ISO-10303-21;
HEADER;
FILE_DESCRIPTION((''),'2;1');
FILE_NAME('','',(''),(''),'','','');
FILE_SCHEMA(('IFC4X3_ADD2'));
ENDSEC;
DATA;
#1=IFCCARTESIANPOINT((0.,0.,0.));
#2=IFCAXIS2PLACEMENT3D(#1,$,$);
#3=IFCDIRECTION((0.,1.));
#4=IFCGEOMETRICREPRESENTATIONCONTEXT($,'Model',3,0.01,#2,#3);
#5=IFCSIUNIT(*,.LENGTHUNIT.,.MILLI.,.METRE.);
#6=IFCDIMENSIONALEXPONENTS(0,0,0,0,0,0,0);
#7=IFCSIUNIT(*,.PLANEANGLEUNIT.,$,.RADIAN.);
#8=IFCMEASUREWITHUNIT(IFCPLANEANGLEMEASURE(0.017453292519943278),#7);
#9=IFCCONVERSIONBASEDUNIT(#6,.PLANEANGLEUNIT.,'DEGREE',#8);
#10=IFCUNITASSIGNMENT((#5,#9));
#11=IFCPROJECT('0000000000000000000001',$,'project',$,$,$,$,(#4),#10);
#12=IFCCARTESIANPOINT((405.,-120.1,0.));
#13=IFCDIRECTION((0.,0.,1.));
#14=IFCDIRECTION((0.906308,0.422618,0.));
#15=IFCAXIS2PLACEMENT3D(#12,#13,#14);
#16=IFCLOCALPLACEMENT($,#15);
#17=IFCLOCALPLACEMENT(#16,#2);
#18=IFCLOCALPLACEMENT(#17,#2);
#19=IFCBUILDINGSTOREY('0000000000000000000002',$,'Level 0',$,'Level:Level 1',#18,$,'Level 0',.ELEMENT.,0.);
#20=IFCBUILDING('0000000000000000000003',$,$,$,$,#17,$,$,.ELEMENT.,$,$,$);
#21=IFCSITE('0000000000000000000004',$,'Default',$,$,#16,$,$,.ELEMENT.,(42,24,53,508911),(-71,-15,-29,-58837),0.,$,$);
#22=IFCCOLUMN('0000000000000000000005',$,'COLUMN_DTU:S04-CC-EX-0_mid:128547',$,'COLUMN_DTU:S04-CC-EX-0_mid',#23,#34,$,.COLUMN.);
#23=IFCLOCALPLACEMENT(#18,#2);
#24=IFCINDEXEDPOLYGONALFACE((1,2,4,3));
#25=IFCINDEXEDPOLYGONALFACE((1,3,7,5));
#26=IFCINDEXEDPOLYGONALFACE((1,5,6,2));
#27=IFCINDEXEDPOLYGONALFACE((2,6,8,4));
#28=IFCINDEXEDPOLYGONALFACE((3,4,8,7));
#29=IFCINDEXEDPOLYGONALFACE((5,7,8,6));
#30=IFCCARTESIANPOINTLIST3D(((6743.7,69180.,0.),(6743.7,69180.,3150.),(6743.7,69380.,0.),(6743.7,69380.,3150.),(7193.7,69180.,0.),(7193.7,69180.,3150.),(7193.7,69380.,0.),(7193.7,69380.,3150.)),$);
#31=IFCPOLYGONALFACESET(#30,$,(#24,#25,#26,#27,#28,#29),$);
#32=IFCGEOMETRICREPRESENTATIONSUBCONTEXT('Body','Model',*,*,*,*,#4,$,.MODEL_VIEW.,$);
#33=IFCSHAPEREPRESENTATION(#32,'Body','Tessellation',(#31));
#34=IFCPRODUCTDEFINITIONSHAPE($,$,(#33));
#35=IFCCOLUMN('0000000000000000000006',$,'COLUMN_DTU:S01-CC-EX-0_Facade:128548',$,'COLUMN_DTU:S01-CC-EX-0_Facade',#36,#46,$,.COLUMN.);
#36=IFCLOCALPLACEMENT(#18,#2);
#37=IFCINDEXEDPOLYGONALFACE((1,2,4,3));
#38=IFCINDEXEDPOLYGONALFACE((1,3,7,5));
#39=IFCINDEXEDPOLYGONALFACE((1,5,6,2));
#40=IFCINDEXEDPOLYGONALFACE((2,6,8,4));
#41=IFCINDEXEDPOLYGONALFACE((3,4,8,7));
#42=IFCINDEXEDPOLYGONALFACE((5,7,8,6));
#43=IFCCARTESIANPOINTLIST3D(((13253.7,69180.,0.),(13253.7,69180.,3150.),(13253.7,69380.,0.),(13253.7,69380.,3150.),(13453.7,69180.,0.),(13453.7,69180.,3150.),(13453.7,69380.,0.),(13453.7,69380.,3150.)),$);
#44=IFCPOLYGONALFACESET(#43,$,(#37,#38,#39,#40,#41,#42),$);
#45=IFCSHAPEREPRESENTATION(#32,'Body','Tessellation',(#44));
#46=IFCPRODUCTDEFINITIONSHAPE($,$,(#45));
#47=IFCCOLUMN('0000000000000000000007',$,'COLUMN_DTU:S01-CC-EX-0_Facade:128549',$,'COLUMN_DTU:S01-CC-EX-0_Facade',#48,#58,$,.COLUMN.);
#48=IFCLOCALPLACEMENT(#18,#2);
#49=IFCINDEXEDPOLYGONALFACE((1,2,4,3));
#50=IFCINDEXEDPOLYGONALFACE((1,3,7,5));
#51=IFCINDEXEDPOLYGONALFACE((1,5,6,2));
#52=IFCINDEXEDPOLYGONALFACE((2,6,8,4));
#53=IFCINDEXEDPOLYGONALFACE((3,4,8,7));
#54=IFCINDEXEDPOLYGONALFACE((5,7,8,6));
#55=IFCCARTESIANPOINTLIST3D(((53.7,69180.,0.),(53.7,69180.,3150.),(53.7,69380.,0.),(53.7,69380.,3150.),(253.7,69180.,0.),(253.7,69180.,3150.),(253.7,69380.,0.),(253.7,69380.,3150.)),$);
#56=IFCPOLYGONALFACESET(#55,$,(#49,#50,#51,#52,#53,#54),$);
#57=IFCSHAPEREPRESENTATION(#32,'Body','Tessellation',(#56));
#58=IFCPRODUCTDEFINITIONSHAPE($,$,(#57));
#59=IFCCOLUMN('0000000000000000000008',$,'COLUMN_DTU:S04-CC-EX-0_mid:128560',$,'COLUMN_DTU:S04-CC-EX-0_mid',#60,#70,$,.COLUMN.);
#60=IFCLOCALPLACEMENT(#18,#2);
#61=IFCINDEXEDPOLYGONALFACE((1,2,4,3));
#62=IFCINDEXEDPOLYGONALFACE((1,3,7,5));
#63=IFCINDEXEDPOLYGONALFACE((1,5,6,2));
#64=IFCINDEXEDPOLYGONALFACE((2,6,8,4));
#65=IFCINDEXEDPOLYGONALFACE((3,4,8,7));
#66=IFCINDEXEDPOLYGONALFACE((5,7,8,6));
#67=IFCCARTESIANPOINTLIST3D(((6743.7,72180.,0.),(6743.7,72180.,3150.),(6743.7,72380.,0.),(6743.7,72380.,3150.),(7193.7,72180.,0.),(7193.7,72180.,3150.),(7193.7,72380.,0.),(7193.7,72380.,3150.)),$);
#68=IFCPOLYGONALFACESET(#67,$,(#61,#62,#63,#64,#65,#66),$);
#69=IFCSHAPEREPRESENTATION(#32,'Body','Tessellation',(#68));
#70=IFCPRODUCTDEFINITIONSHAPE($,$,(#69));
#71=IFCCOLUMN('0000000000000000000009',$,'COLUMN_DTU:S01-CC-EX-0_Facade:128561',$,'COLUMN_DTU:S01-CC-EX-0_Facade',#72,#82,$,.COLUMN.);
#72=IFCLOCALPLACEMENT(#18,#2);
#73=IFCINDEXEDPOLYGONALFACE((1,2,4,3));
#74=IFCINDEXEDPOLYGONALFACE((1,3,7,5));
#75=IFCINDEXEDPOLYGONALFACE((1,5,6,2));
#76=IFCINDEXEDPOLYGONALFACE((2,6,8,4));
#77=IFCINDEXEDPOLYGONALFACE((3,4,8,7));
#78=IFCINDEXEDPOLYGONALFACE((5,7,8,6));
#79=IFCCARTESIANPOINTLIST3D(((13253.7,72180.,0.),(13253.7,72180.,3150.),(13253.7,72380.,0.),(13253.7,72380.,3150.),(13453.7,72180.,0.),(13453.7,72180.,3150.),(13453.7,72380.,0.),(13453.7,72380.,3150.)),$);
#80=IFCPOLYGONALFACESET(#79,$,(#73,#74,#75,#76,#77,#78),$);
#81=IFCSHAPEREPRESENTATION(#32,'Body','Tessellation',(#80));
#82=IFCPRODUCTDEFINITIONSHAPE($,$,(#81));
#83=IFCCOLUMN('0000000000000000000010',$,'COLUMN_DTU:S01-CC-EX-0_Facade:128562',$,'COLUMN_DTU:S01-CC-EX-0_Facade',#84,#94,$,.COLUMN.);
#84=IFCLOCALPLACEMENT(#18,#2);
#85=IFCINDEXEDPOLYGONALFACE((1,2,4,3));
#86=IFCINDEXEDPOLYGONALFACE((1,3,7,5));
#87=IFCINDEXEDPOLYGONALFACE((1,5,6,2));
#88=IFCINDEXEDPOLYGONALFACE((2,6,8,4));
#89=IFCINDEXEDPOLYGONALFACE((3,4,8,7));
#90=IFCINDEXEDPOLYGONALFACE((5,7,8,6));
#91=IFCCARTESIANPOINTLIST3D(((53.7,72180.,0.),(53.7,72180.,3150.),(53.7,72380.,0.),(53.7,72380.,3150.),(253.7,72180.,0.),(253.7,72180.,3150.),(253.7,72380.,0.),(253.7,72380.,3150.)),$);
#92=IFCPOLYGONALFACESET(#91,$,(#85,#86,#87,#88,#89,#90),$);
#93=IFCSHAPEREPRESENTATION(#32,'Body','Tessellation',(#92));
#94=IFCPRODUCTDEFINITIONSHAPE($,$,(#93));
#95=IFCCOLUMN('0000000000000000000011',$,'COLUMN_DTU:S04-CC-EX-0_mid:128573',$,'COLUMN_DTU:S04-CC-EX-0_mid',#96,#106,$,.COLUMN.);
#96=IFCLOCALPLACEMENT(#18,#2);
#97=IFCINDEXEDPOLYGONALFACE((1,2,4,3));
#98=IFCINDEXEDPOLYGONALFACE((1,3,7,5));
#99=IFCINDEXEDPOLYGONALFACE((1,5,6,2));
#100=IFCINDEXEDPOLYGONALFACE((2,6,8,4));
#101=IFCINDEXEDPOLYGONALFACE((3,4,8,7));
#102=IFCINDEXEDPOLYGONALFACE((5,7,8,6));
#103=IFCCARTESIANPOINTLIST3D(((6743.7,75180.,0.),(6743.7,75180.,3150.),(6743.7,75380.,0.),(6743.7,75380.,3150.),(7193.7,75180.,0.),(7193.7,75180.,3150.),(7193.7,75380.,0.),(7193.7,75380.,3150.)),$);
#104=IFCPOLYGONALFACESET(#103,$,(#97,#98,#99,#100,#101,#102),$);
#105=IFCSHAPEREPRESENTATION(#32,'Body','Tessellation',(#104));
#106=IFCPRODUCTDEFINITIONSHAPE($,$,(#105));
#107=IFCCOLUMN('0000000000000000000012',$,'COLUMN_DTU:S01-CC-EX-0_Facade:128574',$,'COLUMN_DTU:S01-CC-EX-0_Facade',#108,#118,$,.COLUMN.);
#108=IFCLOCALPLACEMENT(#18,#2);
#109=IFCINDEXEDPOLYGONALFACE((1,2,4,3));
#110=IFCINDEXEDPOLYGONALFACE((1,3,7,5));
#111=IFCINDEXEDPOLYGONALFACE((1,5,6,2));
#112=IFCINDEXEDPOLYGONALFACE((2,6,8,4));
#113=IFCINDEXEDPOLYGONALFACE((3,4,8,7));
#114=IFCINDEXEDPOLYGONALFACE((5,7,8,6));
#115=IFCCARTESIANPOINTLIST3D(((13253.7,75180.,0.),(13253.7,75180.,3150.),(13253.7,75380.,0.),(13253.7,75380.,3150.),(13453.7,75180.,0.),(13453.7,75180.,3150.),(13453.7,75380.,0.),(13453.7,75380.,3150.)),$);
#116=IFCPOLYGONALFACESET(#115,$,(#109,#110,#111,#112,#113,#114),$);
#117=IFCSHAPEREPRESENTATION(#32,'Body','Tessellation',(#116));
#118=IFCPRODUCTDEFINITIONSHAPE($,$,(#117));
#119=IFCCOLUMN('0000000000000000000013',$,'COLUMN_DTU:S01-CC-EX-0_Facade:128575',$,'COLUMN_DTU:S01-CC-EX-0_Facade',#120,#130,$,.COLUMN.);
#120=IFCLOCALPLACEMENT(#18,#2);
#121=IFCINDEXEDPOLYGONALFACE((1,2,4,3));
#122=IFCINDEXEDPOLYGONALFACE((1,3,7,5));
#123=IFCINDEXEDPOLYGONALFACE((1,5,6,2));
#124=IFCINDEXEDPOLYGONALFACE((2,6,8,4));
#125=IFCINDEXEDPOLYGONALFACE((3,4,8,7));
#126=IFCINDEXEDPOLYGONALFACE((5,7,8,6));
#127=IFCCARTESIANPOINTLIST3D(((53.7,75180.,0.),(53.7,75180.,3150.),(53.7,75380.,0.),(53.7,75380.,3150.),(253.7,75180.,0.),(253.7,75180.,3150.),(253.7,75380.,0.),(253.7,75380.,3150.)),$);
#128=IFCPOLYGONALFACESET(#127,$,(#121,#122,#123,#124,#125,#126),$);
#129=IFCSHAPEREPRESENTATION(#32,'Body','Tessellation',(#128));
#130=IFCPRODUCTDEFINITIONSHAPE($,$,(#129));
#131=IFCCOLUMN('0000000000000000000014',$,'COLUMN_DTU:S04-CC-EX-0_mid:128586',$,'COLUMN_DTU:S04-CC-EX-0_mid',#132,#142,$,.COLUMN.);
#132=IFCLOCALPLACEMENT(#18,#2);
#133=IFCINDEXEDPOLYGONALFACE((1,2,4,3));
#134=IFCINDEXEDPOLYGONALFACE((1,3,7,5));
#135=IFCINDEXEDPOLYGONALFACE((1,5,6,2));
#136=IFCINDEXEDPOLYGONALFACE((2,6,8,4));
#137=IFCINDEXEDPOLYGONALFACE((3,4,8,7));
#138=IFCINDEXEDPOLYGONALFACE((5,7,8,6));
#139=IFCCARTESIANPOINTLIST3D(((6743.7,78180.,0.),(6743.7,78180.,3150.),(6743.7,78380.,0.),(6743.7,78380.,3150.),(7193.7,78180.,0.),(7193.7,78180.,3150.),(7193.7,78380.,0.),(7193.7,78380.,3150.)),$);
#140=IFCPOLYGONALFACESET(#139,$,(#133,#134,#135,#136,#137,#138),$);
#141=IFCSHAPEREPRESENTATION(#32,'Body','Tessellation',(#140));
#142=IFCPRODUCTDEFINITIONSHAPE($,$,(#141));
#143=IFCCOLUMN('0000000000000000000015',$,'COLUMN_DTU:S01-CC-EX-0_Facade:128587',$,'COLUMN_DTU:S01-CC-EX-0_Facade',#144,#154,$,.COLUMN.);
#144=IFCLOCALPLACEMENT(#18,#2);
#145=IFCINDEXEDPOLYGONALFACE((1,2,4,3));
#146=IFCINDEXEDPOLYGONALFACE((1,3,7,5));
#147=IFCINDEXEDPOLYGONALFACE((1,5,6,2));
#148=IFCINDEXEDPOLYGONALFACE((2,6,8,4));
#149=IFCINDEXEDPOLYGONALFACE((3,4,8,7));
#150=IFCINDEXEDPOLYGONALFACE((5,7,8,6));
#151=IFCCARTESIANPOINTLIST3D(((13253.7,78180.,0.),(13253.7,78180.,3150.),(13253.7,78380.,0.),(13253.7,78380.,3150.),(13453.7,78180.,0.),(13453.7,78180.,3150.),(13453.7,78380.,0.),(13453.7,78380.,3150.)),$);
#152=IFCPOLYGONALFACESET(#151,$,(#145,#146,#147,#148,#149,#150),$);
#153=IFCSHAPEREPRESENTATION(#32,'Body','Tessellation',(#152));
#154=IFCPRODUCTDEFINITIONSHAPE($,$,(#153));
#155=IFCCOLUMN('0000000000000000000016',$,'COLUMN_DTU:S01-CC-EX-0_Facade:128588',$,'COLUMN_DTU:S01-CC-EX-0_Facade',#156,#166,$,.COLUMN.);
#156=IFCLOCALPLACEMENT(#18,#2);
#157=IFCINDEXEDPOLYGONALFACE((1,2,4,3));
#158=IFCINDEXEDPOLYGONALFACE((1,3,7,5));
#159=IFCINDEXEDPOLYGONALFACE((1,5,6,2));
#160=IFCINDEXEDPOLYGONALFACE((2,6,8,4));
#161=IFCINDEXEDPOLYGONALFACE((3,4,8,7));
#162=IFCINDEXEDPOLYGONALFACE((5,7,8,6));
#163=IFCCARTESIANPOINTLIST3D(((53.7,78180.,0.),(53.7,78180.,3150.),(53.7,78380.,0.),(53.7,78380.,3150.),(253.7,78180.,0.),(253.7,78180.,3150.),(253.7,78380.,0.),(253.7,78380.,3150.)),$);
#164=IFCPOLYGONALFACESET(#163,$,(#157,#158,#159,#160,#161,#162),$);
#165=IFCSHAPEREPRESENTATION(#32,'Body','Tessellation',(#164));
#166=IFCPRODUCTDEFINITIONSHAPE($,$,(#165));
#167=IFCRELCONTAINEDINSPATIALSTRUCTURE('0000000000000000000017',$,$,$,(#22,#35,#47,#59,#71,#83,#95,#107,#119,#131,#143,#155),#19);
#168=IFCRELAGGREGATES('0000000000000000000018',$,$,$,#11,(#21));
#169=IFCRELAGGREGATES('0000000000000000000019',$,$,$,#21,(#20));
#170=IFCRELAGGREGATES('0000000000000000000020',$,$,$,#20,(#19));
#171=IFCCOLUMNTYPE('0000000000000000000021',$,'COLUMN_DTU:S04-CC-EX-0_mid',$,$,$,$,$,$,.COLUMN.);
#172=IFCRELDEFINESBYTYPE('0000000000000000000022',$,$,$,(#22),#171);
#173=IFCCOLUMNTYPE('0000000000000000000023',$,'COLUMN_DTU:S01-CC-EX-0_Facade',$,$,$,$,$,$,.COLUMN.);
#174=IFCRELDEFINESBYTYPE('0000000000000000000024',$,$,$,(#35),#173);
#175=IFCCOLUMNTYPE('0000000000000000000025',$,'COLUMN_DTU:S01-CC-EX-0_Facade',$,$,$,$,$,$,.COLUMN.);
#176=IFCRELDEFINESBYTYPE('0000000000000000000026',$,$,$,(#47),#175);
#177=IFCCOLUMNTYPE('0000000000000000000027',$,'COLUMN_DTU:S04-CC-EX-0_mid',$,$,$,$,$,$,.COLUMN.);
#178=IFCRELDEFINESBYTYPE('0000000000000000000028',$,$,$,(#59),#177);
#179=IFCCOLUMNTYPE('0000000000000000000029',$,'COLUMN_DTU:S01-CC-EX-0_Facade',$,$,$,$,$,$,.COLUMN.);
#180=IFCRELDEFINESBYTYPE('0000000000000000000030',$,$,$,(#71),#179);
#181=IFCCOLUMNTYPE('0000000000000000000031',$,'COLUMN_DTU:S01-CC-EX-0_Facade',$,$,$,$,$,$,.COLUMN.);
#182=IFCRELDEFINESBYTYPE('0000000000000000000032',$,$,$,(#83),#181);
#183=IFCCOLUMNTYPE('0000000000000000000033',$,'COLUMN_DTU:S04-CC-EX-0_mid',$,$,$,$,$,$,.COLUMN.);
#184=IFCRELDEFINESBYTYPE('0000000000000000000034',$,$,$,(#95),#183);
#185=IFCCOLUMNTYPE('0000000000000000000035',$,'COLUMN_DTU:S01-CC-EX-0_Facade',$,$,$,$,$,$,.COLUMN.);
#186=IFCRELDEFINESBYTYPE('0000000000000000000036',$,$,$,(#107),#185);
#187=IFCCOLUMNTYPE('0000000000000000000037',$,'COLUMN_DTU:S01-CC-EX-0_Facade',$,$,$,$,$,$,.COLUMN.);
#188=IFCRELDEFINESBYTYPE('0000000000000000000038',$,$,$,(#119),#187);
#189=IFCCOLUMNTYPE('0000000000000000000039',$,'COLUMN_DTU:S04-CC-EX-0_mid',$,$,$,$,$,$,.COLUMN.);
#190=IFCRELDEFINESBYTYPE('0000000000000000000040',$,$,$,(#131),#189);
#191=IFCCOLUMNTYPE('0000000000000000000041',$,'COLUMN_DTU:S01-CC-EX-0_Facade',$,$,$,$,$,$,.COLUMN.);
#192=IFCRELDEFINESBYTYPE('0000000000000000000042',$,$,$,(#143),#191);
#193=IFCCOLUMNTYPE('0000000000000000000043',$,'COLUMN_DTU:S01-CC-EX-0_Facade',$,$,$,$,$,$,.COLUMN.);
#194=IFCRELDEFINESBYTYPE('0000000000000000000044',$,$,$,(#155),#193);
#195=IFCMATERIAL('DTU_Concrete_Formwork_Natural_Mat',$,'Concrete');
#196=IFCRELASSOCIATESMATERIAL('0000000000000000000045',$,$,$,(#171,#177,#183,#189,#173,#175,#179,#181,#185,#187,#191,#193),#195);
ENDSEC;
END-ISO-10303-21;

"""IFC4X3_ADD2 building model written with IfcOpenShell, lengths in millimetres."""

from ifc_helpers import new_model, entity, si_unit, converted_unit, direction, frame, frame_2d, origin, place, context, subcontext, project, spatial, rectangle, extrude, source, transform, mapped, material, material_profile, profile_set, type_object, type_shapes, element, save


model = new_model("IFC4X3_ADD2")

# Units and contexts
model_context = context("Model", 3, precision=0.01, world=origin(), true_north=direction((0.0, 1.0)))
body_context = subcontext(model_context, "Body", "Model", "MODEL_VIEW")
ifc_project = project(units=[si_unit("LENGTHUNIT", "METRE", prefix="MILLI"), converted_unit("PLANEANGLEUNIT", "DEGREE", entity("IfcPlaneAngleMeasure", 0.017453292519943278), si_unit("PLANEANGLEUNIT", "RADIAN"), dimensions=[0, 0, 0, 0, 0, 0, 0])], contexts=[model_context])

# Site, building, storey
site_placement = place(None, frame((405.0, -120.1, 0.0), z_axis=(0.0, 0.0, 1.0), x_axis=(0.906308, 0.422618, 0.0)))
site = spatial("IfcSite", under=ifc_project, at=site_placement, Name="Default", CompositionType="ELEMENT", RefLatitude=(42, 24, 53, 508911), RefLongitude=(-71, -15, -29, -58837), RefElevation=0.0)
building_placement = place(site_placement, origin())
building = spatial("IfcBuilding", under=site, at=building_placement, CompositionType="ELEMENT")
storey_placement = place(building_placement, origin())
storey = spatial("IfcBuildingStorey", under=building, at=storey_placement, Name="Level 0", ObjectType="Level:Level 1", LongName="Level 0", CompositionType="ELEMENT", Elevation=0.0)

# Columns
ifc_material = material(Name="DTU_Concrete_Formwork_Natural_Mat", Category="Concrete")
ifc_material_profile_1 = material_profile(ifc_material, rectangle(XDim=200.0, YDim=200.0, at=frame_2d((0.0, 0.0), x_axis=(1.0, 0.0))), Name="S01-CC-EX-0_Facade")
ifc_profile_set_1 = profile_set([ifc_material_profile_1], Name="S01-CC-EX-0_Facade")
ifc_material_profile_2 = material_profile(ifc_material, rectangle(XDim=200.0, YDim=450.0, at=frame_2d((0.0, 0.0), x_axis=(1.0, 0.0))), Name="S04-CC-EX-0_mid")
ifc_profile_set_2 = profile_set([ifc_material_profile_2], Name="S04-CC-EX-0_mid")
column_type_1 = type_object("IfcColumnType", Name="COLUMN_DTU:S04-CC-EX-0_mid", PredefinedType="COLUMN", material=ifc_profile_set_2)
shared_shape_1 = source(origin(), body_context, "Body", "SweptSolid", [
    extrude(rectangle(XDim=200.0, YDim=450.0, at=frame_2d((0.0, 0.0), x_axis=(1.0, 0.0))), frame((6968.7, 69280.0, 0.0), z_axis=(0.0, 0.0, 1.0), x_axis=(0.0, 1.0, 0.0)), (0.0, 0.0, 1.0), 3150.0),
])
type_shapes(column_type_1, [shared_shape_1])
column_1_placement = place(storey_placement, origin())
element("IfcColumn", 1, at=column_1_placement, inside=storey, type_object=column_type_1, Name="COLUMN_DTU:S04-CC-EX-0_mid:128547", ObjectType="COLUMN_DTU:S04-CC-EX-0_mid", PredefinedType="COLUMN", context=body_context, shape_type="MappedRepresentation", body=[
    mapped(shared_shape_1, transform((0.0, 0.0, 0.0), scale=1.0)),
])
column_type_2 = type_object("IfcColumnType", Name="COLUMN_DTU:S01-CC-EX-0_Facade", PredefinedType="COLUMN", material=ifc_profile_set_1)
shared_shape_2 = source(origin(), body_context, "Body", "SweptSolid", [
    extrude(rectangle(XDim=200.0, YDim=200.0, at=frame_2d((0.0, 0.0), x_axis=(1.0, 0.0))), frame((13353.7, 69280.0, 0.0), z_axis=(0.0, 0.0, 1.0), x_axis=(0.0, 1.0, 0.0)), (0.0, 0.0, 1.0), 3150.0),
])
type_shapes(column_type_2, [shared_shape_2])
column_2_placement = place(storey_placement, origin())
element("IfcColumn", 2, at=column_2_placement, inside=storey, type_object=column_type_2, Name="COLUMN_DTU:S01-CC-EX-0_Facade:128548", ObjectType="COLUMN_DTU:S01-CC-EX-0_Facade", PredefinedType="COLUMN", context=body_context, shape_type="MappedRepresentation", body=[
    mapped(shared_shape_2, transform((0.0, 0.0, 0.0), scale=1.0)),
])
column_type_3 = type_object("IfcColumnType", Name="COLUMN_DTU:S01-CC-EX-0_Facade", PredefinedType="COLUMN", material=ifc_profile_set_1)
shared_shape_3 = source(origin(), body_context, "Body", "SweptSolid", [
    extrude(rectangle(XDim=200.0, YDim=200.0, at=frame_2d((0.0, 0.0), x_axis=(1.0, 0.0))), frame((153.7, 69280.0, 0.0), z_axis=(0.0, 0.0, 1.0), x_axis=(0.0, 1.0, 0.0)), (0.0, 0.0, 1.0), 3150.0),
])
type_shapes(column_type_3, [shared_shape_3])
column_3_placement = place(storey_placement, origin())
element("IfcColumn", 3, at=column_3_placement, inside=storey, type_object=column_type_3, Name="COLUMN_DTU:S01-CC-EX-0_Facade:128549", ObjectType="COLUMN_DTU:S01-CC-EX-0_Facade", PredefinedType="COLUMN", context=body_context, shape_type="MappedRepresentation", body=[
    mapped(shared_shape_3, transform((0.0, 0.0, 0.0), scale=1.0)),
])
column_type_4 = type_object("IfcColumnType", Name="COLUMN_DTU:S04-CC-EX-0_mid", PredefinedType="COLUMN", material=ifc_profile_set_2)
shared_shape_4 = source(origin(), body_context, "Body", "SweptSolid", [
    extrude(rectangle(XDim=200.0, YDim=450.0, at=frame_2d((0.0, 0.0), x_axis=(1.0, 0.0))), frame((6968.7, 72280.0, 0.0), z_axis=(0.0, 0.0, 1.0), x_axis=(0.0, 1.0, 0.0)), (0.0, 0.0, 1.0), 3150.0),
])
type_shapes(column_type_4, [shared_shape_4])
column_4_placement = place(storey_placement, origin())
element("IfcColumn", 4, at=column_4_placement, inside=storey, type_object=column_type_4, Name="COLUMN_DTU:S04-CC-EX-0_mid:128560", ObjectType="COLUMN_DTU:S04-CC-EX-0_mid", PredefinedType="COLUMN", context=body_context, shape_type="MappedRepresentation", body=[
    mapped(shared_shape_4, transform((0.0, 0.0, 0.0), scale=1.0)),
])
column_type_5 = type_object("IfcColumnType", Name="COLUMN_DTU:S01-CC-EX-0_Facade", PredefinedType="COLUMN", material=ifc_profile_set_1)
shared_shape_5 = source(origin(), body_context, "Body", "SweptSolid", [
    extrude(rectangle(XDim=200.0, YDim=200.0, at=frame_2d((0.0, 0.0), x_axis=(1.0, 0.0))), frame((13353.7, 72280.0, 0.0), z_axis=(0.0, 0.0, 1.0), x_axis=(0.0, 1.0, 0.0)), (0.0, 0.0, 1.0), 3150.0),
])
type_shapes(column_type_5, [shared_shape_5])
column_5_placement = place(storey_placement, origin())
element("IfcColumn", 5, at=column_5_placement, inside=storey, type_object=column_type_5, Name="COLUMN_DTU:S01-CC-EX-0_Facade:128561", ObjectType="COLUMN_DTU:S01-CC-EX-0_Facade", PredefinedType="COLUMN", context=body_context, shape_type="MappedRepresentation", body=[
    mapped(shared_shape_5, transform((0.0, 0.0, 0.0), scale=1.0)),
])
column_type_6 = type_object("IfcColumnType", Name="COLUMN_DTU:S01-CC-EX-0_Facade", PredefinedType="COLUMN", material=ifc_profile_set_1)
shared_shape_6 = source(origin(), body_context, "Body", "SweptSolid", [
    extrude(rectangle(XDim=200.0, YDim=200.0, at=frame_2d((0.0, 0.0), x_axis=(1.0, 0.0))), frame((153.7, 72280.0, 0.0), z_axis=(0.0, 0.0, 1.0), x_axis=(0.0, 1.0, 0.0)), (0.0, 0.0, 1.0), 3150.0),
])
type_shapes(column_type_6, [shared_shape_6])
column_6_placement = place(storey_placement, origin())
element("IfcColumn", 6, at=column_6_placement, inside=storey, type_object=column_type_6, Name="COLUMN_DTU:S01-CC-EX-0_Facade:128562", ObjectType="COLUMN_DTU:S01-CC-EX-0_Facade", PredefinedType="COLUMN", context=body_context, shape_type="MappedRepresentation", body=[
    mapped(shared_shape_6, transform((0.0, 0.0, 0.0), scale=1.0)),
])
column_type_7 = type_object("IfcColumnType", Name="COLUMN_DTU:S04-CC-EX-0_mid", PredefinedType="COLUMN", material=ifc_profile_set_2)
shared_shape_7 = source(origin(), body_context, "Body", "SweptSolid", [
    extrude(rectangle(XDim=200.0, YDim=450.0, at=frame_2d((0.0, 0.0), x_axis=(1.0, 0.0))), frame((6968.7, 75280.0, 0.0), z_axis=(0.0, 0.0, 1.0), x_axis=(0.0, 1.0, 0.0)), (0.0, 0.0, 1.0), 3150.0),
])
type_shapes(column_type_7, [shared_shape_7])
column_7_placement = place(storey_placement, origin())
element("IfcColumn", 7, at=column_7_placement, inside=storey, type_object=column_type_7, Name="COLUMN_DTU:S04-CC-EX-0_mid:128573", ObjectType="COLUMN_DTU:S04-CC-EX-0_mid", PredefinedType="COLUMN", context=body_context, shape_type="MappedRepresentation", body=[
    mapped(shared_shape_7, transform((0.0, 0.0, 0.0), scale=1.0)),
])
column_type_8 = type_object("IfcColumnType", Name="COLUMN_DTU:S01-CC-EX-0_Facade", PredefinedType="COLUMN", material=ifc_profile_set_1)
shared_shape_8 = source(origin(), body_context, "Body", "SweptSolid", [
    extrude(rectangle(XDim=200.0, YDim=200.0, at=frame_2d((0.0, 0.0), x_axis=(1.0, 0.0))), frame((13353.7, 75280.0, 0.0), z_axis=(0.0, 0.0, 1.0), x_axis=(0.0, 1.0, 0.0)), (0.0, 0.0, 1.0), 3150.0),
])
type_shapes(column_type_8, [shared_shape_8])
column_8_placement = place(storey_placement, origin())
element("IfcColumn", 8, at=column_8_placement, inside=storey, type_object=column_type_8, Name="COLUMN_DTU:S01-CC-EX-0_Facade:128574", ObjectType="COLUMN_DTU:S01-CC-EX-0_Facade", PredefinedType="COLUMN", context=body_context, shape_type="MappedRepresentation", body=[
    mapped(shared_shape_8, transform((0.0, 0.0, 0.0), scale=1.0)),
])
column_type_9 = type_object("IfcColumnType", Name="COLUMN_DTU:S01-CC-EX-0_Facade", PredefinedType="COLUMN", material=ifc_profile_set_1)
shared_shape_9 = source(origin(), body_context, "Body", "SweptSolid", [
    extrude(rectangle(XDim=200.0, YDim=200.0, at=frame_2d((0.0, 0.0), x_axis=(1.0, 0.0))), frame((153.7, 75280.0, 0.0), z_axis=(0.0, 0.0, 1.0), x_axis=(0.0, 1.0, 0.0)), (0.0, 0.0, 1.0), 3150.0),
])
type_shapes(column_type_9, [shared_shape_9])
column_9_placement = place(storey_placement, origin())
element("IfcColumn", 9, at=column_9_placement, inside=storey, type_object=column_type_9, Name="COLUMN_DTU:S01-CC-EX-0_Facade:128575", ObjectType="COLUMN_DTU:S01-CC-EX-0_Facade", PredefinedType="COLUMN", context=body_context, shape_type="MappedRepresentation", body=[
    mapped(shared_shape_9, transform((0.0, 0.0, 0.0), scale=1.0)),
])
column_type_10 = type_object("IfcColumnType", Name="COLUMN_DTU:S04-CC-EX-0_mid", PredefinedType="COLUMN", material=ifc_profile_set_2)
shared_shape_10 = source(origin(), body_context, "Body", "SweptSolid", [
    extrude(rectangle(XDim=200.0, YDim=450.0, at=frame_2d((0.0, 0.0), x_axis=(1.0, 0.0))), frame((6968.7, 78280.0, 0.0), z_axis=(0.0, 0.0, 1.0), x_axis=(0.0, 1.0, 0.0)), (0.0, 0.0, 1.0), 3150.0),
])
type_shapes(column_type_10, [shared_shape_10])
column_10_placement = place(storey_placement, origin())
element("IfcColumn", 10, at=column_10_placement, inside=storey, type_object=column_type_10, Name="COLUMN_DTU:S04-CC-EX-0_mid:128586", ObjectType="COLUMN_DTU:S04-CC-EX-0_mid", PredefinedType="COLUMN", context=body_context, shape_type="MappedRepresentation", body=[
    mapped(shared_shape_10, transform((0.0, 0.0, 0.0), scale=1.0)),
])
column_type_11 = type_object("IfcColumnType", Name="COLUMN_DTU:S01-CC-EX-0_Facade", PredefinedType="COLUMN", material=ifc_profile_set_1)
shared_shape_11 = source(origin(), body_context, "Body", "SweptSolid", [
    extrude(rectangle(XDim=200.0, YDim=200.0, at=frame_2d((0.0, 0.0), x_axis=(1.0, 0.0))), frame((13353.7, 78280.0, 0.0), z_axis=(0.0, 0.0, 1.0), x_axis=(0.0, 1.0, 0.0)), (0.0, 0.0, 1.0), 3150.0),
])
type_shapes(column_type_11, [shared_shape_11])
column_11_placement = place(storey_placement, origin())
element("IfcColumn", 11, at=column_11_placement, inside=storey, type_object=column_type_11, Name="COLUMN_DTU:S01-CC-EX-0_Facade:128587", ObjectType="COLUMN_DTU:S01-CC-EX-0_Facade", PredefinedType="COLUMN", context=body_context, shape_type="MappedRepresentation", body=[
    mapped(shared_shape_11, transform((0.0, 0.0, 0.0), scale=1.0)),
])
column_type_12 = type_object("IfcColumnType", Name="COLUMN_DTU:S01-CC-EX-0_Facade", PredefinedType="COLUMN", material=ifc_profile_set_1)
shared_shape_12 = source(origin(), body_context, "Body", "SweptSolid", [
    extrude(rectangle(XDim=200.0, YDim=200.0, at=frame_2d((0.0, 0.0), x_axis=(1.0, 0.0))), frame((153.7, 78280.0, 0.0), z_axis=(0.0, 0.0, 1.0), x_axis=(0.0, 1.0, 0.0)), (0.0, 0.0, 1.0), 3150.0),
])
type_shapes(column_type_12, [shared_shape_12])
column_12_placement = place(storey_placement, origin())
element("IfcColumn", 12, at=column_12_placement, inside=storey, type_object=column_type_12, Name="COLUMN_DTU:S01-CC-EX-0_Facade:128588", ObjectType="COLUMN_DTU:S01-CC-EX-0_Facade", PredefinedType="COLUMN", context=body_context, shape_type="MappedRepresentation", body=[
    mapped(shared_shape_12, transform((0.0, 0.0, 0.0), scale=1.0)),
])

save(model, "model.ifc")
